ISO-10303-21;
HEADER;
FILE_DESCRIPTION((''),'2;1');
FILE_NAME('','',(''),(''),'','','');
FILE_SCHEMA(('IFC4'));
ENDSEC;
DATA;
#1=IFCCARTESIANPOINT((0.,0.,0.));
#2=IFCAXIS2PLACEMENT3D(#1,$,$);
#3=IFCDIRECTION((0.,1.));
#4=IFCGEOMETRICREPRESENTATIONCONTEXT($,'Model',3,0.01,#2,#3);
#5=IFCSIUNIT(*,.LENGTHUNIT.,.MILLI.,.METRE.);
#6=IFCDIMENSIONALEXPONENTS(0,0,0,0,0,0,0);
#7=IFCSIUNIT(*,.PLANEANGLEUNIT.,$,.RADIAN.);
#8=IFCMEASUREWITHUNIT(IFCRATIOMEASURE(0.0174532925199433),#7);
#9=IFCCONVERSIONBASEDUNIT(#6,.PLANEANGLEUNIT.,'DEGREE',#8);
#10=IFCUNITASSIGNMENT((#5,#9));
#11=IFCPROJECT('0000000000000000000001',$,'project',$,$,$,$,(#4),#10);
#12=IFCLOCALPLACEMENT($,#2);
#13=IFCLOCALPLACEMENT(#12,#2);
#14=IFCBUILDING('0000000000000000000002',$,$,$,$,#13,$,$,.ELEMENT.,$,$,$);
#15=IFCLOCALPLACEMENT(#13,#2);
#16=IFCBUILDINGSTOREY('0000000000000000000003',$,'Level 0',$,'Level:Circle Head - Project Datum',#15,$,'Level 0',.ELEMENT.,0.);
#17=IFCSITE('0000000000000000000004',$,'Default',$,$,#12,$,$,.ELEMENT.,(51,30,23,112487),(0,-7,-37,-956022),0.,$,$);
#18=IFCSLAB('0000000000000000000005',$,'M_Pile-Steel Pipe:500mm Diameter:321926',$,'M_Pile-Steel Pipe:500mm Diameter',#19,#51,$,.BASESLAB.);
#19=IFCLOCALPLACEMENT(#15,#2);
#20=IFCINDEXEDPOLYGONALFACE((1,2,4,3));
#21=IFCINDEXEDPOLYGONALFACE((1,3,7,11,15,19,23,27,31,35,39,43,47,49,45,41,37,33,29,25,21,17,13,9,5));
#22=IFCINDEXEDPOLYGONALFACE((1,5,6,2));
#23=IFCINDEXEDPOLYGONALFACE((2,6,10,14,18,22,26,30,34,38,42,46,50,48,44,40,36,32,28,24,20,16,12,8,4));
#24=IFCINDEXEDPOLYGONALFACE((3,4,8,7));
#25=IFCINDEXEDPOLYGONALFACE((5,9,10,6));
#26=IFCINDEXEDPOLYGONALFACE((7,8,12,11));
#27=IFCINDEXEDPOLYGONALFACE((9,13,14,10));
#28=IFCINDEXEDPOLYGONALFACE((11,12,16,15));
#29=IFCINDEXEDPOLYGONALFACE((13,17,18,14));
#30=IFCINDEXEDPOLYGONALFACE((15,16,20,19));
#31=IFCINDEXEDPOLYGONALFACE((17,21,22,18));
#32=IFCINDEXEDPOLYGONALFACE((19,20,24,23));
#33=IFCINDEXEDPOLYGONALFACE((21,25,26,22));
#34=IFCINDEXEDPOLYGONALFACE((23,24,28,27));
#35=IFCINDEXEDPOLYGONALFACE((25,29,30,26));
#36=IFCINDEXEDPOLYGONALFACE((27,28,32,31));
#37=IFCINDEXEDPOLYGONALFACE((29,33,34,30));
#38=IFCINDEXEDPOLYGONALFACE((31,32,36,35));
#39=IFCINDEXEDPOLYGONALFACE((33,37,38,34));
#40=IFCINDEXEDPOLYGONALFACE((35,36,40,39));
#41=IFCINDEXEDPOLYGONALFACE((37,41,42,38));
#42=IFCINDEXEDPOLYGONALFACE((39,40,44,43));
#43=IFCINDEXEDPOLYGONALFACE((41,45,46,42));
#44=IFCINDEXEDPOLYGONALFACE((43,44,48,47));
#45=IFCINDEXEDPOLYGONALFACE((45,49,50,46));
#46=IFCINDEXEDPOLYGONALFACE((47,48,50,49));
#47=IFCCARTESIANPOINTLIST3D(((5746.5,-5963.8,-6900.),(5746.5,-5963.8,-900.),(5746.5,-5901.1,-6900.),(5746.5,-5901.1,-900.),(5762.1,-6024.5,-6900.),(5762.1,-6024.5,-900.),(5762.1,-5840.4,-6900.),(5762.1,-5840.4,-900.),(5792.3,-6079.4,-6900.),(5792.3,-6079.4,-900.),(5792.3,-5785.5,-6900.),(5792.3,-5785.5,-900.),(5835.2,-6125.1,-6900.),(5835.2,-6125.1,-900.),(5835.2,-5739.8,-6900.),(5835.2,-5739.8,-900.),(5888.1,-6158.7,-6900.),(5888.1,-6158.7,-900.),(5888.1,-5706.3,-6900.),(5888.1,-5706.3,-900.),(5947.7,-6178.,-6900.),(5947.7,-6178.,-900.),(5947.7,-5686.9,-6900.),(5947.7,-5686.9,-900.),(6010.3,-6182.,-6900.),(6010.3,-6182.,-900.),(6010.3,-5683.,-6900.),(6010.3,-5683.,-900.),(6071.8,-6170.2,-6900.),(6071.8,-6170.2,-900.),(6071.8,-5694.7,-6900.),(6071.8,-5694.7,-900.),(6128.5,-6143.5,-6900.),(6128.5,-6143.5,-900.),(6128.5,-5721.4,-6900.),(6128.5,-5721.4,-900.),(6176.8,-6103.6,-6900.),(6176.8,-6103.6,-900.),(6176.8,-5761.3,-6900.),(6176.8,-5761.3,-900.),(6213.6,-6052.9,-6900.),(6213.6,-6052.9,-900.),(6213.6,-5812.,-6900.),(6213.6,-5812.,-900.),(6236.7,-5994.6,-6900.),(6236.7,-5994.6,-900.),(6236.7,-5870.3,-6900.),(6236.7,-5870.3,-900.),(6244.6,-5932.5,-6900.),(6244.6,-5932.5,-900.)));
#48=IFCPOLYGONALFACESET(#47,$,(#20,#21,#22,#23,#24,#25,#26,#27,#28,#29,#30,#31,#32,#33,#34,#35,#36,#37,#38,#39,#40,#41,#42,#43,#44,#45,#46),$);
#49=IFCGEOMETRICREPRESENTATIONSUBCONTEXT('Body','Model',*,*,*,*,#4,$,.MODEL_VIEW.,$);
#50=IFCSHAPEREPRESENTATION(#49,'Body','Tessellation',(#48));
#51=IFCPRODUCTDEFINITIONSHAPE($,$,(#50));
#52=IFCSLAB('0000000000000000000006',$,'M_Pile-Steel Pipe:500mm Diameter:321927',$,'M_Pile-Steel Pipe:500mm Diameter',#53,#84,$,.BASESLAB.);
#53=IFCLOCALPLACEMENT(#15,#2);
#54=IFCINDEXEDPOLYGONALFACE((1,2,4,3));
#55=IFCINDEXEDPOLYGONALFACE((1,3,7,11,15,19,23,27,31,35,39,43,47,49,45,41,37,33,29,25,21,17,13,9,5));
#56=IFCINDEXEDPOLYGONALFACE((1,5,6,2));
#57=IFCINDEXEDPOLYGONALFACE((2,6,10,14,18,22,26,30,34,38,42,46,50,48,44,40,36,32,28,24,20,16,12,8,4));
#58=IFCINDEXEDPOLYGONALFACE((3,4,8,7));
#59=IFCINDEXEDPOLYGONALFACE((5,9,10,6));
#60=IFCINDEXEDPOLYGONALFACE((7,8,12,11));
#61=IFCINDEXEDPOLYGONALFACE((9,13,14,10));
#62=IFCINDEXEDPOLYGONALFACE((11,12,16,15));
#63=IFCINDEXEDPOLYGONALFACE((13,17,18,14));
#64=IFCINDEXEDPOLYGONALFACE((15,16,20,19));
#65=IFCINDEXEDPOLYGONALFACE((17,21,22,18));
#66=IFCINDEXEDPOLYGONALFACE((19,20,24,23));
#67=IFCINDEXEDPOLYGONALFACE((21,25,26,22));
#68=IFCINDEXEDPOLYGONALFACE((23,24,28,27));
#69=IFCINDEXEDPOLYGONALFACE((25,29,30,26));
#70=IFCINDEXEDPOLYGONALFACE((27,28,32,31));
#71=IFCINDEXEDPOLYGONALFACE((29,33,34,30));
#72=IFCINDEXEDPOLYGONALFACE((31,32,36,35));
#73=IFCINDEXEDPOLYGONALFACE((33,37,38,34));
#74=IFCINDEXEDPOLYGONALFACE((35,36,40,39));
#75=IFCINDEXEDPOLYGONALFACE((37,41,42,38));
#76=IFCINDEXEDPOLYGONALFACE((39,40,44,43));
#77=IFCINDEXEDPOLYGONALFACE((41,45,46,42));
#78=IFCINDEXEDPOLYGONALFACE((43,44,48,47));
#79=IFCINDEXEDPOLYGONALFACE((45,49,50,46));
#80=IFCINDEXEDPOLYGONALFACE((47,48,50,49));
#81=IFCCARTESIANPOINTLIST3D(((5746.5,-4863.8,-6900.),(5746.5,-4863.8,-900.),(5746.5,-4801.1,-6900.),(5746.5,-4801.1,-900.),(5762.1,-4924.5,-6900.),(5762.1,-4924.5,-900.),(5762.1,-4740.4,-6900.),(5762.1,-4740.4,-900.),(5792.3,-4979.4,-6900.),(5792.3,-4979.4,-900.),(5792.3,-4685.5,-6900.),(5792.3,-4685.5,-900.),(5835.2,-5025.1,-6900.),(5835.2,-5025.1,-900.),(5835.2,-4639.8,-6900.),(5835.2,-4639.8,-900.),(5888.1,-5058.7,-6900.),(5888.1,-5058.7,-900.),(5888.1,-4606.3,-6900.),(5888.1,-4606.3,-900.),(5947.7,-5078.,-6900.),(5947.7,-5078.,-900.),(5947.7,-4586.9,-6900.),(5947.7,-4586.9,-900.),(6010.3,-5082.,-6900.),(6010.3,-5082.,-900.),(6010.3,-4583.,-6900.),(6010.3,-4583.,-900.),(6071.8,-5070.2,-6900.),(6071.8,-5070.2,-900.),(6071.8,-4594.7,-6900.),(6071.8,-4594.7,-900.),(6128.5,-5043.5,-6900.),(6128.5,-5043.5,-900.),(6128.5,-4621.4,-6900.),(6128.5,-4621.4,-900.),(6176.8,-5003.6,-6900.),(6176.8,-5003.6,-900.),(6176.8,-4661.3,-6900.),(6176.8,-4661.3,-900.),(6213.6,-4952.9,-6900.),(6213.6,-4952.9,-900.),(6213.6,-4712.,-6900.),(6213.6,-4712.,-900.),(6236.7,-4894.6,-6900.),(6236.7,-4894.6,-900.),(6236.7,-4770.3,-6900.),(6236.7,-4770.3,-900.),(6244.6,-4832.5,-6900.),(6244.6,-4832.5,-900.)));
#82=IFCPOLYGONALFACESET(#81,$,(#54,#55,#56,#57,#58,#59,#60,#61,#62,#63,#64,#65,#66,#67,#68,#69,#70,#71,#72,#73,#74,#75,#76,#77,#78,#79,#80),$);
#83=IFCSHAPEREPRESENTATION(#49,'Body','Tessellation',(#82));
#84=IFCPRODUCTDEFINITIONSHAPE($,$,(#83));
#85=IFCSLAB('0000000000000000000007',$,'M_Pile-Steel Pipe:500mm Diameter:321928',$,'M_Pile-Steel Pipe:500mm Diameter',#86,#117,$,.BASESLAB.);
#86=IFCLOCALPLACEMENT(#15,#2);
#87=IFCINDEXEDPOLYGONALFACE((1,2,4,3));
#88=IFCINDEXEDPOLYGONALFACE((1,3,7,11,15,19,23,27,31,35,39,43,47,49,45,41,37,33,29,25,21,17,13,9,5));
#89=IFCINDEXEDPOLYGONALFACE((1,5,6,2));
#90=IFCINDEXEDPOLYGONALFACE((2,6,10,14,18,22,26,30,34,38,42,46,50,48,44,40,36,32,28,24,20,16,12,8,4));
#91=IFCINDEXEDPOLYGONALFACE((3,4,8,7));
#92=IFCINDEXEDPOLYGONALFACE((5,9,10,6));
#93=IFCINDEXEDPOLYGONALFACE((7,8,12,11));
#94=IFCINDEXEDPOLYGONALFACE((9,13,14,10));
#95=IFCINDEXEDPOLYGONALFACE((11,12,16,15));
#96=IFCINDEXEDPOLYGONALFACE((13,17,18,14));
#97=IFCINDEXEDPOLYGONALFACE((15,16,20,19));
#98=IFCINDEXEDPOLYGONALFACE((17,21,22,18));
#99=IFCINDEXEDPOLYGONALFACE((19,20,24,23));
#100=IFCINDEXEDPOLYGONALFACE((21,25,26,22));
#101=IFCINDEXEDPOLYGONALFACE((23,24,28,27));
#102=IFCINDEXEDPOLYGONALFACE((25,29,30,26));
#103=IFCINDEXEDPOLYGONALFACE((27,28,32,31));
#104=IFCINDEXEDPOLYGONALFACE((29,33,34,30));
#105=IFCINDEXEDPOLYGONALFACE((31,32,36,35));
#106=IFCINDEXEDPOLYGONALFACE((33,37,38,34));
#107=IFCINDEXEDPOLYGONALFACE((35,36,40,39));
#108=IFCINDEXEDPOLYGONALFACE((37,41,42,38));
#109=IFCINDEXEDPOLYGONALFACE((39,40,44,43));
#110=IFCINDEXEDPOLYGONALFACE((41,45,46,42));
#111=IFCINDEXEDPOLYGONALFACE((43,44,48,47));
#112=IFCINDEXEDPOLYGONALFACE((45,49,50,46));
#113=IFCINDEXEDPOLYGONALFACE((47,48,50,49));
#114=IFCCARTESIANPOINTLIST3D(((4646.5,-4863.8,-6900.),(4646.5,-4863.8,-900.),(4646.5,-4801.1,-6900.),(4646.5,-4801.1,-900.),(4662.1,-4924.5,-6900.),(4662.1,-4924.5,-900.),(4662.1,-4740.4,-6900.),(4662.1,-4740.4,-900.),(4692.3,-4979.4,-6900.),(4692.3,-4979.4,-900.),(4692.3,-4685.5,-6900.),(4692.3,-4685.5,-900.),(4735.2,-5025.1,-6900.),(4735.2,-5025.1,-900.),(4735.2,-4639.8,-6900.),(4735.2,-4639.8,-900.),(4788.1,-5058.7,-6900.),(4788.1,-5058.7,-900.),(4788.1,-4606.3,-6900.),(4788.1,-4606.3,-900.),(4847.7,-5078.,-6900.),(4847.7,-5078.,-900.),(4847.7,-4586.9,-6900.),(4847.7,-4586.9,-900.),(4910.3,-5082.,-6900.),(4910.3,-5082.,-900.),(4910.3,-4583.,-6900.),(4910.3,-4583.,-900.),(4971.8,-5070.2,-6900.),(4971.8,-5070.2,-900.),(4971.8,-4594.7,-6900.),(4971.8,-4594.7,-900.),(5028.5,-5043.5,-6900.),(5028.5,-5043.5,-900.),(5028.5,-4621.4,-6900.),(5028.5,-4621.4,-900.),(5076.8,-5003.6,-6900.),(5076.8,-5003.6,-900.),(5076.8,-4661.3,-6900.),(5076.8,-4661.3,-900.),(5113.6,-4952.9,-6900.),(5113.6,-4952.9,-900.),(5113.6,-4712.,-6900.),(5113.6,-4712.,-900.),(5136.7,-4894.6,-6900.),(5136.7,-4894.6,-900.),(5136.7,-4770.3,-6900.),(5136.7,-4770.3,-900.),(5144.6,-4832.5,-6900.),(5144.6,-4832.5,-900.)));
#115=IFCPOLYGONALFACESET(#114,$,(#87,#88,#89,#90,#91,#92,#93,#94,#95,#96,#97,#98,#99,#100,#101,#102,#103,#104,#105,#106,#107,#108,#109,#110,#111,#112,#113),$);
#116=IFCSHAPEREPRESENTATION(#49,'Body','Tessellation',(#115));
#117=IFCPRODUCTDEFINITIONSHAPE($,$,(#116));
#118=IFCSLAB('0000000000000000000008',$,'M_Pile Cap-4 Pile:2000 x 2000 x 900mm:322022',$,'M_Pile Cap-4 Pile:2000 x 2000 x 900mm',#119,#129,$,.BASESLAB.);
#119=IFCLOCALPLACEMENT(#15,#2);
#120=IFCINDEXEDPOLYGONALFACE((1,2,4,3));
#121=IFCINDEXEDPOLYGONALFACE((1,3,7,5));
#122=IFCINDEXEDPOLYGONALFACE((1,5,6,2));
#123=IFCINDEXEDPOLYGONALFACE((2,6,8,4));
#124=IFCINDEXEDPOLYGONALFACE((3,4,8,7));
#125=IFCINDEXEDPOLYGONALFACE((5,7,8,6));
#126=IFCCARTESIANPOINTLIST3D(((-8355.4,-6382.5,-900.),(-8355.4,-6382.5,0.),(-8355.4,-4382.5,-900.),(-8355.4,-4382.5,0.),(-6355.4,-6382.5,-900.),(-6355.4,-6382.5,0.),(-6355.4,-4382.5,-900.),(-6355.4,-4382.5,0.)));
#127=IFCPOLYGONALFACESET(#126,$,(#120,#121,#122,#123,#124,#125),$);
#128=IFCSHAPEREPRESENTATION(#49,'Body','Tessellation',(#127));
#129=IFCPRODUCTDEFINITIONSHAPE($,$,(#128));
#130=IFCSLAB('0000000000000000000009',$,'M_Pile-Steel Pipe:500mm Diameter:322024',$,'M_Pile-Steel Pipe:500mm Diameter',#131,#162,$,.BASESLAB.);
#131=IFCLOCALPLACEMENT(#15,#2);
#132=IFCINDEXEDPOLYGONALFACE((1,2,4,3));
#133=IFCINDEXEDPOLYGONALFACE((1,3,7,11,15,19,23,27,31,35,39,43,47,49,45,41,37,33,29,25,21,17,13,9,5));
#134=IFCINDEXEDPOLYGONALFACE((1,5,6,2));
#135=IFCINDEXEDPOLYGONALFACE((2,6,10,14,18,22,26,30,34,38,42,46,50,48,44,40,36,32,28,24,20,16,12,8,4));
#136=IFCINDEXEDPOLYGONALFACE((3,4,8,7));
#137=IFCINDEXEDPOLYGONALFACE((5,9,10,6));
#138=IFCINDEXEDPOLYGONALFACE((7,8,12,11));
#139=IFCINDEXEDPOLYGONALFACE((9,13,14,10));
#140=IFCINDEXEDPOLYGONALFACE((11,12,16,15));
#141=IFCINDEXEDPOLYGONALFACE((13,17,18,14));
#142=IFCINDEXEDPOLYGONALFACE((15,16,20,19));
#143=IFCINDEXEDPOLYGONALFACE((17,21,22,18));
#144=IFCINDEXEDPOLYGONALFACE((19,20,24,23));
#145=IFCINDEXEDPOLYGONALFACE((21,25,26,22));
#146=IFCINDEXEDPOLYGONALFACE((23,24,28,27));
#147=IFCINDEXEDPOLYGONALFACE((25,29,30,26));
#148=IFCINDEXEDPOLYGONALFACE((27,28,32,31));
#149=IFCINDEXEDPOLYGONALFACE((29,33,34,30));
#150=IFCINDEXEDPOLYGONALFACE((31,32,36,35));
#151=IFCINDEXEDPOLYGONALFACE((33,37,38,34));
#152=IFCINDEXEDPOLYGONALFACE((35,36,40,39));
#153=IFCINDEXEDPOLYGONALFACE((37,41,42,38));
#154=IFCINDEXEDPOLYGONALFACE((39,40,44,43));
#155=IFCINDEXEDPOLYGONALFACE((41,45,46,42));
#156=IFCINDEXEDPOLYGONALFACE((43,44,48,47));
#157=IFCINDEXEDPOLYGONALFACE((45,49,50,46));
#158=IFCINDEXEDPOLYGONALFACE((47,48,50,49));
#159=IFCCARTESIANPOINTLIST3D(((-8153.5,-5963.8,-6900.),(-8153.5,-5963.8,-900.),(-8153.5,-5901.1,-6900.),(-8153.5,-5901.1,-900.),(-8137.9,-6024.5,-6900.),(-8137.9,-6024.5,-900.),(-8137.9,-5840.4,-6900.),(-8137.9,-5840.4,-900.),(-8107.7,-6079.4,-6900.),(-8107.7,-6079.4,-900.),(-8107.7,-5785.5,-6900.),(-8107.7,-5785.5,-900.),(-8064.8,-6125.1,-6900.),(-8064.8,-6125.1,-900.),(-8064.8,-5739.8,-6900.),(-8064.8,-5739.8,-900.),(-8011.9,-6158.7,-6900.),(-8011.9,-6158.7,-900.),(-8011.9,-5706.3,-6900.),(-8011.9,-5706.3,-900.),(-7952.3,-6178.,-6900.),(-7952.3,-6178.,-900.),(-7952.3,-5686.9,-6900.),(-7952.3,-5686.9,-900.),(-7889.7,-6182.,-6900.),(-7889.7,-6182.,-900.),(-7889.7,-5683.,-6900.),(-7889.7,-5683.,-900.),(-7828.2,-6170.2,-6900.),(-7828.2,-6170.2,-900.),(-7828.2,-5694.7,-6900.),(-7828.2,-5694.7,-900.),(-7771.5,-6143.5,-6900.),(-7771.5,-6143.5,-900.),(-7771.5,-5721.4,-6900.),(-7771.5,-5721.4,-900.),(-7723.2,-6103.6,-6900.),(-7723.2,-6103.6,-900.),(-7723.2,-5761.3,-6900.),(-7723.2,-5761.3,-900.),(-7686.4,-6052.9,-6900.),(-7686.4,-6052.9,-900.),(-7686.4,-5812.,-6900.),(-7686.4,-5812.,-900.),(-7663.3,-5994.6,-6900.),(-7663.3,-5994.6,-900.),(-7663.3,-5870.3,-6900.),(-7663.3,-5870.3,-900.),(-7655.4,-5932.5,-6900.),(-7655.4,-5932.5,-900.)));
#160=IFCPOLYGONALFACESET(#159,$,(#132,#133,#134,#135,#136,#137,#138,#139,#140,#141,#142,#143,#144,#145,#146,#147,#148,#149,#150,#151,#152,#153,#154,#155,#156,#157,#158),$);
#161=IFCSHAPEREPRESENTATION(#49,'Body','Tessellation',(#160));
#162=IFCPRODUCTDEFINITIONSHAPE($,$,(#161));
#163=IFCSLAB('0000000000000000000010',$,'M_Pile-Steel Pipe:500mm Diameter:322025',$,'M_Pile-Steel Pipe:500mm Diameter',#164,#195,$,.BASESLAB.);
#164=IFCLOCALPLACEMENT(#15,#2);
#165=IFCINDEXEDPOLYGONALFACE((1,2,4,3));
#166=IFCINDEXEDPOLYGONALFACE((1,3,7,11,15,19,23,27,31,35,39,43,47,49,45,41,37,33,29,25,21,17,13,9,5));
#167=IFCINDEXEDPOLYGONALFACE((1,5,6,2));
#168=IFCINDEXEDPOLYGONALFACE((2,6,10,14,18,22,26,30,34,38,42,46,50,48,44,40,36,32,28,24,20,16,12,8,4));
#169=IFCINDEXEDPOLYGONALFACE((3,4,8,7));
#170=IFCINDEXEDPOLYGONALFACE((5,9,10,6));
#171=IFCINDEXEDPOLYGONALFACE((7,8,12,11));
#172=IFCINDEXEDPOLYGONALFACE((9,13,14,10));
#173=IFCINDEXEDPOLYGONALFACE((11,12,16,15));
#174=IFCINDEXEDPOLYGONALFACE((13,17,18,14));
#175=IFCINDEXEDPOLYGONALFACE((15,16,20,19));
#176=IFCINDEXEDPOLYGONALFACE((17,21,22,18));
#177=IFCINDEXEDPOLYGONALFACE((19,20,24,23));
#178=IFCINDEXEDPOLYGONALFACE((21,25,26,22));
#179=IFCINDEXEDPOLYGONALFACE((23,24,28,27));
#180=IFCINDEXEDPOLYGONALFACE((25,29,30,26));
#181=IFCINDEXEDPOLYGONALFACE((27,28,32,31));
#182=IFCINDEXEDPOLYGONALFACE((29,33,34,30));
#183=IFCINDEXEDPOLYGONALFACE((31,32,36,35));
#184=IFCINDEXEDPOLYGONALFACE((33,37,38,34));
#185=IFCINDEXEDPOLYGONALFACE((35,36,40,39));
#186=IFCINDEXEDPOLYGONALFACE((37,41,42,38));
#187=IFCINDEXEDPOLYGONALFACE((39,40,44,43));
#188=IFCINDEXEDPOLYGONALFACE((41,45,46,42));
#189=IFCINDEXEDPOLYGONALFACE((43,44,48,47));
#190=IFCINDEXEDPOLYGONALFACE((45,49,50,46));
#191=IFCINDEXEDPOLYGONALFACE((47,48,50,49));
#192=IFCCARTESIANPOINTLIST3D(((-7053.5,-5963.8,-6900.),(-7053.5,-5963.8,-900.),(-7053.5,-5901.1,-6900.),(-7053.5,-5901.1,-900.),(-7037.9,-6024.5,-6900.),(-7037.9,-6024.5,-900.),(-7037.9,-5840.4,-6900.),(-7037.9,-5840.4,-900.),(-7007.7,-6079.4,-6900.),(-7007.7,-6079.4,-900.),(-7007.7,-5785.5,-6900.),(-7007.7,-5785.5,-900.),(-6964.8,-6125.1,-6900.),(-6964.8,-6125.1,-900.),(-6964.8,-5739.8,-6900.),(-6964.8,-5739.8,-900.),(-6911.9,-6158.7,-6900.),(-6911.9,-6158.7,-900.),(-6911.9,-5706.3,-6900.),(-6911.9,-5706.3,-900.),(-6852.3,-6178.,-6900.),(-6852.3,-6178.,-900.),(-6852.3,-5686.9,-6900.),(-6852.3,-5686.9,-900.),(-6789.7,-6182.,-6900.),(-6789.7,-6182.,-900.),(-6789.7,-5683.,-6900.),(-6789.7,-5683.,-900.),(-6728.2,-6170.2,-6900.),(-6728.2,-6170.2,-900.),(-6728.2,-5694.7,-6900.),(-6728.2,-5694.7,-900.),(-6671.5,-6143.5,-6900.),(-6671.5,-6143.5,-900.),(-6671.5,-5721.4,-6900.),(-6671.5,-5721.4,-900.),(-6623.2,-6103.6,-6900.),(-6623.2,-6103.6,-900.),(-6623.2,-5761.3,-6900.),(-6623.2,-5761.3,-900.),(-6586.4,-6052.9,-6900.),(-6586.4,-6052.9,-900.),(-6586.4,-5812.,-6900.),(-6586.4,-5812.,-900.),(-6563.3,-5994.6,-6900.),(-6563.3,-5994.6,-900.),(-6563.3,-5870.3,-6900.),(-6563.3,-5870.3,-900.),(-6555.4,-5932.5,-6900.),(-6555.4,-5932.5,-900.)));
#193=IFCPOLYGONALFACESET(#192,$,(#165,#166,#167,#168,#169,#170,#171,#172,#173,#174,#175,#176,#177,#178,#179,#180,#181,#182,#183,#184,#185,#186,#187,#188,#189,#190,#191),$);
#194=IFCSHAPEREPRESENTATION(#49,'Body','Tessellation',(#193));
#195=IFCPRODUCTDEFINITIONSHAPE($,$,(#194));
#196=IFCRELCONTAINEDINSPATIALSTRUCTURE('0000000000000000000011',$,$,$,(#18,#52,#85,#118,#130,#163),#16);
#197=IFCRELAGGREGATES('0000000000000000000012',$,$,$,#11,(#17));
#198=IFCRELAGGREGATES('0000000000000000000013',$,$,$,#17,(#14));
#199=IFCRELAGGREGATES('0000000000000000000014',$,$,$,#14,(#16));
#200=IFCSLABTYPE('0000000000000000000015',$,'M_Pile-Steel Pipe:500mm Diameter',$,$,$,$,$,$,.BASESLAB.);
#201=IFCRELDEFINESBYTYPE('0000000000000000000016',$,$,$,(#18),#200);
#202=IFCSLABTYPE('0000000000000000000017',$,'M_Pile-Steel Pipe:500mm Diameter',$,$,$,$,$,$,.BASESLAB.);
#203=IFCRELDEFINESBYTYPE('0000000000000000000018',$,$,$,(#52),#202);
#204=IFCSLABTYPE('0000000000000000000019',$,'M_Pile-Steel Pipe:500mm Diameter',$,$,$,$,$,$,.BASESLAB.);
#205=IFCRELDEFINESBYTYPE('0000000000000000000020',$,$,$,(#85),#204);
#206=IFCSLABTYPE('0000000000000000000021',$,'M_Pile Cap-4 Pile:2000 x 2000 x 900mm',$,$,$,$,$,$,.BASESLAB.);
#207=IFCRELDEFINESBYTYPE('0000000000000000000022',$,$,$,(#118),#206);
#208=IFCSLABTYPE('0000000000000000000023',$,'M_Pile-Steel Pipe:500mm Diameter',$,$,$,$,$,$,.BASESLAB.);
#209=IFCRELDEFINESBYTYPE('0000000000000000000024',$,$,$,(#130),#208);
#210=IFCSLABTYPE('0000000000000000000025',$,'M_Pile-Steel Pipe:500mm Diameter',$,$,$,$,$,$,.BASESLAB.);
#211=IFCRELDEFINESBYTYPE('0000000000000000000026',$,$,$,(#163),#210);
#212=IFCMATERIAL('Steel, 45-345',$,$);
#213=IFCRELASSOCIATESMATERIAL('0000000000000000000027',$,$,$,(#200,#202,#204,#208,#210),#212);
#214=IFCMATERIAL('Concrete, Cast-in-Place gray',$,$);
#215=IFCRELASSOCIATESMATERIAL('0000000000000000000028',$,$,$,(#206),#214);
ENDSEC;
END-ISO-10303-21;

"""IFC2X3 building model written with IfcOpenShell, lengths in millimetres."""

from ifc_helpers import new_model, entity, si_unit, converted_unit, direction, frame, frame_2d, origin, origin_2d_with_axis, place, context, subcontext, project, spatial, rectangle, circle, extrude, material, type_object, element, save


model = new_model("IFC2X3")

# Units and contexts
model_context = context("Model", 3, precision=0.01, world=origin(), true_north=direction((0.0, 1.0)))
body_context = subcontext(model_context, "Body", "Model", "MODEL_VIEW")
ifc_project = project(units=[si_unit("LENGTHUNIT", "METRE", prefix="MILLI"), converted_unit("PLANEANGLEUNIT", "DEGREE", entity("IfcRatioMeasure", 0.0174532925199433), si_unit("PLANEANGLEUNIT", "RADIAN"), dimensions=[0, 0, 0, 0, 0, 0, 0])], contexts=[model_context])

# Site, building, storey
site_placement = place(None, origin())
site = spatial("IfcSite", under=ifc_project, at=site_placement, Name="Default", CompositionType="ELEMENT", RefLatitude=(51, 30, 23, 112487), RefLongitude=(0, -7, -37, -956022), RefElevation=0.0)
building_placement = place(site_placement, origin())
building = spatial("IfcBuilding", under=site, at=building_placement, CompositionType="ELEMENT")
storey_placement = place(building_placement, origin())
storey = spatial("IfcBuildingStorey", under=building, at=storey_placement, Name="Level 0", ObjectType="Level:Circle Head - Project Datum", LongName="Level 0", CompositionType="ELEMENT", Elevation=0.0)

# Slabs
ifc_material_1 = material(Name="Concrete, Cast-in-Place gray")
ifc_material_2 = material(Name="Steel, 45-345")
slab_type_1 = type_object("IfcSlabType", Name="M_Pile-Steel Pipe:500mm Diameter", PredefinedType="BASESLAB", material=ifc_material_2)
slab_1_placement = place(storey_placement, origin())
element("IfcSlab", 1, at=slab_1_placement, inside=storey, type_object=slab_type_1, Name="M_Pile-Steel Pipe:500mm Diameter:321926", ObjectType="M_Pile-Steel Pipe:500mm Diameter", PredefinedType="BASESLAB", context=body_context, shape_type="SweptSolid", body=[
    extrude(circle(Radius=250.0, at=origin_2d_with_axis()), frame((5994.6, -5932.5, -6900.0)), (0.0, 0.0, 1.0), 6000.0),
])
slab_type_2 = type_object("IfcSlabType", Name="M_Pile-Steel Pipe:500mm Diameter", PredefinedType="BASESLAB", material=ifc_material_2)
slab_2_placement = place(storey_placement, origin())
element("IfcSlab", 2, at=slab_2_placement, inside=storey, type_object=slab_type_2, Name="M_Pile-Steel Pipe:500mm Diameter:321927", ObjectType="M_Pile-Steel Pipe:500mm Diameter", PredefinedType="BASESLAB", context=body_context, shape_type="SweptSolid", body=[
    extrude(circle(Radius=250.0, at=frame_2d((0.0, 0.0), x_axis=(1.0, 0.0))), frame((5994.6, -4832.5, -6900.0)), (0.0, 0.0, 1.0), 6000.0),
])
slab_type_3 = type_object("IfcSlabType", Name="M_Pile-Steel Pipe:500mm Diameter", PredefinedType="BASESLAB", material=ifc_material_2)
slab_3_placement = place(storey_placement, origin())
element("IfcSlab", 3, at=slab_3_placement, inside=storey, type_object=slab_type_3, Name="M_Pile-Steel Pipe:500mm Diameter:321928", ObjectType="M_Pile-Steel Pipe:500mm Diameter", PredefinedType="BASESLAB", context=body_context, shape_type="SweptSolid", body=[
    extrude(circle(Radius=250.0, at=frame_2d((0.0, 0.0), x_axis=(1.0, 0.0))), frame((4894.6, -4832.5, -6900.0)), (0.0, 0.0, 1.0), 6000.0),
])
slab_type_4 = type_object("IfcSlabType", Name="M_Pile Cap-4 Pile:2000 x 2000 x 900mm", PredefinedType="BASESLAB", material=ifc_material_1)
slab_4_placement = place(storey_placement, origin())
element("IfcSlab", 4, at=slab_4_placement, inside=storey, type_object=slab_type_4, Name="M_Pile Cap-4 Pile:2000 x 2000 x 900mm:322022", ObjectType="M_Pile Cap-4 Pile:2000 x 2000 x 900mm", PredefinedType="BASESLAB", context=body_context, shape_type="SweptSolid", body=[
    extrude(rectangle(XDim=2000.0, YDim=2000.0, at=frame_2d((0.0, 0.0), x_axis=(1.0, 0.0))), frame((-7355.4, -5382.5, -900.0), z_axis=(0.0, 0.0, 1.0), x_axis=(-1.0, 0.0, 0.0)), (0.0, 0.0, 1.0), 900.0),
])
slab_type_5 = type_object("IfcSlabType", Name="M_Pile-Steel Pipe:500mm Diameter", PredefinedType="BASESLAB", material=ifc_material_2)
slab_5_placement = place(storey_placement, origin())
element("IfcSlab", 5, at=slab_5_placement, inside=storey, type_object=slab_type_5, Name="M_Pile-Steel Pipe:500mm Diameter:322024", ObjectType="M_Pile-Steel Pipe:500mm Diameter", PredefinedType="BASESLAB", context=body_context, shape_type="SweptSolid", body=[
    extrude(circle(Radius=250.0, at=origin_2d_with_axis()), frame((-7905.4, -5932.5, -6900.0)), (0.0, 0.0, 1.0), 6000.0),
])
slab_type_6 = type_object("IfcSlabType", Name="M_Pile-Steel Pipe:500mm Diameter", PredefinedType="BASESLAB", material=ifc_material_2)
slab_6_placement = place(storey_placement, origin())
element("IfcSlab", 6, at=slab_6_placement, inside=storey, type_object=slab_type_6, Name="M_Pile-Steel Pipe:500mm Diameter:322025", ObjectType="M_Pile-Steel Pipe:500mm Diameter", PredefinedType="BASESLAB", context=body_context, shape_type="SweptSolid", body=[
    extrude(circle(Radius=250.0, at=origin_2d_with_axis()), frame((-6805.4, -5932.5, -6900.0)), (0.0, 0.0, 1.0), 6000.0),
])

save(model, "model.ifc")
